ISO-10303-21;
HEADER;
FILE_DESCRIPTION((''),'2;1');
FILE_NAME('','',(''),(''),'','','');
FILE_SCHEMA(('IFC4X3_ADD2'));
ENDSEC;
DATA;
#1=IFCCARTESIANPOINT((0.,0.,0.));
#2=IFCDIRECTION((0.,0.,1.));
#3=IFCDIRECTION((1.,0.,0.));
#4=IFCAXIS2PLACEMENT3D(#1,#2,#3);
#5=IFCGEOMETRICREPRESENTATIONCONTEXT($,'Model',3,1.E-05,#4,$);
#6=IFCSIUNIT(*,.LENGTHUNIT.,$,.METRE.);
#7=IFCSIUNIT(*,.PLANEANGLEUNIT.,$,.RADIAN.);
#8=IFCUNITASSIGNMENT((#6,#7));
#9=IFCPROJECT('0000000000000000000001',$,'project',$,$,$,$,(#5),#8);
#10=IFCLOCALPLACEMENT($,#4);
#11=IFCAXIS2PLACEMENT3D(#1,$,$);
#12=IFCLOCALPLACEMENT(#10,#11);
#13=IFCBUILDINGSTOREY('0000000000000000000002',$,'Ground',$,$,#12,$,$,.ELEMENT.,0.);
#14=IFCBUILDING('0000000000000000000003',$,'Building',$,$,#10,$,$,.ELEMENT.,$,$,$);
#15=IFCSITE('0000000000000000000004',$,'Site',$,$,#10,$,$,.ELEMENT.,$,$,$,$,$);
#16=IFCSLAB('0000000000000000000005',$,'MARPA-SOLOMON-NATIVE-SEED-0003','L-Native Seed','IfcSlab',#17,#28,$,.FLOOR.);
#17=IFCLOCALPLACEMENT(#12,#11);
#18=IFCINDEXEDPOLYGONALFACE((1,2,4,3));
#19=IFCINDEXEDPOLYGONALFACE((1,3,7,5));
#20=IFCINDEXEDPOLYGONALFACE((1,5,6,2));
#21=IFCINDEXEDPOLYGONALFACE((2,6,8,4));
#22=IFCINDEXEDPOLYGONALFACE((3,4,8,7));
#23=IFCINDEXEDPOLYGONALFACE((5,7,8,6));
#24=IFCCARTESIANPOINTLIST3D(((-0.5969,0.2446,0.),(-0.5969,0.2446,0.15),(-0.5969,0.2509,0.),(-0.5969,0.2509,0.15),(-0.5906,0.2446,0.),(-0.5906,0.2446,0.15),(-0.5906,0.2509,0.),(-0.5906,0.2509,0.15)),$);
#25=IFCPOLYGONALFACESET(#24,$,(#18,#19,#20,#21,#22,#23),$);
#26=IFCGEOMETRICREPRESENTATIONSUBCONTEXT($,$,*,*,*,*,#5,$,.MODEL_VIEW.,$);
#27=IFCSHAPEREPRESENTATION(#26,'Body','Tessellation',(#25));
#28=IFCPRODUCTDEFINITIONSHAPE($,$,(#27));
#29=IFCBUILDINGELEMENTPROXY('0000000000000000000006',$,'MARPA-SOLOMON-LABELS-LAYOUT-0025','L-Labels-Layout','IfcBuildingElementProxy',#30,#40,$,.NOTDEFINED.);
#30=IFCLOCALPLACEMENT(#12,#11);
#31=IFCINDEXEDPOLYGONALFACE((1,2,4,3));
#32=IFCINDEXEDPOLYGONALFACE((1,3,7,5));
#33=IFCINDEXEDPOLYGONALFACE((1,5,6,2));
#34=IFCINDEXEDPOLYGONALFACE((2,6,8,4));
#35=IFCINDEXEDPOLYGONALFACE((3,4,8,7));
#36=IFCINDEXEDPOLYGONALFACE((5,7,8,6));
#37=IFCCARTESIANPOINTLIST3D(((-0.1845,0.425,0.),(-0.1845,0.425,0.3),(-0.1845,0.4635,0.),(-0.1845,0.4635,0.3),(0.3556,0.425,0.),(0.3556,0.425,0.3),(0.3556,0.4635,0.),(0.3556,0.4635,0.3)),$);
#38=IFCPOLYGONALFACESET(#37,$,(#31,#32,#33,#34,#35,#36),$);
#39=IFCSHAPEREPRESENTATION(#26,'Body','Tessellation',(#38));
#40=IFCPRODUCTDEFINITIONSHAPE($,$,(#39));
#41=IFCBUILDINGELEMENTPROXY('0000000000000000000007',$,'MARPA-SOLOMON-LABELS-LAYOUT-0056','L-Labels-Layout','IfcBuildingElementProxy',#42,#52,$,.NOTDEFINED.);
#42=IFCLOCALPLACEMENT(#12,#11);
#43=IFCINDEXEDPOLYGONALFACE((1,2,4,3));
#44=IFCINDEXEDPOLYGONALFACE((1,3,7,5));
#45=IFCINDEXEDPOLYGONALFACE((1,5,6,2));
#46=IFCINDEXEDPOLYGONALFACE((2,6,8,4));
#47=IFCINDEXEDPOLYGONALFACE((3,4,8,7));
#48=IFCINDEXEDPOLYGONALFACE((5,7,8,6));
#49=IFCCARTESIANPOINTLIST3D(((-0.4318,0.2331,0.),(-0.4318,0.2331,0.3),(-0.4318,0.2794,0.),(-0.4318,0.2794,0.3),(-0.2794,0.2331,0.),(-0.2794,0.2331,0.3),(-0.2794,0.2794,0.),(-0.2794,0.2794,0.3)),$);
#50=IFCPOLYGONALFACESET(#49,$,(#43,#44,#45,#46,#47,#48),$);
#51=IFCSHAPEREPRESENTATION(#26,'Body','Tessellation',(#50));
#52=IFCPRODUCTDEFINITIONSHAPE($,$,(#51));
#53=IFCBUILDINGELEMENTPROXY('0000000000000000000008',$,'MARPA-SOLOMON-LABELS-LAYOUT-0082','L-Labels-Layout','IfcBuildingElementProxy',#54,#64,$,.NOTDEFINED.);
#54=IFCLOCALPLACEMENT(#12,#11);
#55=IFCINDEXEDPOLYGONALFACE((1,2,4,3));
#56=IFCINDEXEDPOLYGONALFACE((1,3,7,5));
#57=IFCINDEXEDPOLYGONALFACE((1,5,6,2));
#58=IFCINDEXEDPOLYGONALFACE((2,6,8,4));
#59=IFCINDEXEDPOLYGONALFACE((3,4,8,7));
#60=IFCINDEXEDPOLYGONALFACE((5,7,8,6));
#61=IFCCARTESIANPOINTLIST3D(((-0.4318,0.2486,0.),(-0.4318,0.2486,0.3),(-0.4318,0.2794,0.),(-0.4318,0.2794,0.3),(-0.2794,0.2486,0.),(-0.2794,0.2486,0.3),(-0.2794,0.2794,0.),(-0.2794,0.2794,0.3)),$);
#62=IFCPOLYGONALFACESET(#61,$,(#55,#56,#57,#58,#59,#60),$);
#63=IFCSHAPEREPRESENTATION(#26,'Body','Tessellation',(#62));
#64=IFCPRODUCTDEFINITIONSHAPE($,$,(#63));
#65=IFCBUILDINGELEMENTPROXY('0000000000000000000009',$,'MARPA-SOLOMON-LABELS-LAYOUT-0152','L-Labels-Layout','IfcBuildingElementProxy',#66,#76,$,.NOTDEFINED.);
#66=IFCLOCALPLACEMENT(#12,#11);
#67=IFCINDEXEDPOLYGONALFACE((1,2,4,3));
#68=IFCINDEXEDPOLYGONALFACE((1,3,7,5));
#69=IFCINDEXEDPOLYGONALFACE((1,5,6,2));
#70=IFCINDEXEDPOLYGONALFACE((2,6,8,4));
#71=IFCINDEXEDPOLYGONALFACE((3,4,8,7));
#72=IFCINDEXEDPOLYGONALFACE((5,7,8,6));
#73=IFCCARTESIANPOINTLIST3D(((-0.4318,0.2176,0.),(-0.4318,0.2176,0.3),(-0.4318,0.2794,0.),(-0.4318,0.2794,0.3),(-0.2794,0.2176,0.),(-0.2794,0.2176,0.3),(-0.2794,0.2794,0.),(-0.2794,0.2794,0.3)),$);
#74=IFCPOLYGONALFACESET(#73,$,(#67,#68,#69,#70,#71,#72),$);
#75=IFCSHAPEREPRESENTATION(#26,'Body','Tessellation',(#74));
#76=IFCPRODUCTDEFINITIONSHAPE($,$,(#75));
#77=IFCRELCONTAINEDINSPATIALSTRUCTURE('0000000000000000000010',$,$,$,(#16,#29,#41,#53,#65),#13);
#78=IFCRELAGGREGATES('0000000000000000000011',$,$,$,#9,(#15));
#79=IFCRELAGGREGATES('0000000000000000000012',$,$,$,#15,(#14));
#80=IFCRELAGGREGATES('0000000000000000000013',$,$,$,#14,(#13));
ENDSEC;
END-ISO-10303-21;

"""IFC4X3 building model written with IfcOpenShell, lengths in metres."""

from ifc_helpers import new_model, si_unit, frame, origin, origin_with_axes, place, context, subcontext, project, spatial, polyline, outline, extrude, element, save


model = new_model("IFC4X3")

# Units and contexts
model_context = context("Model", 3, precision=1e-05, world=origin_with_axes())
sub_context = subcontext(model_context, None, None, "MODEL_VIEW")
ifc_project = project(units=[si_unit("LENGTHUNIT", "METRE"), si_unit("PLANEANGLEUNIT", "RADIAN")], contexts=[model_context])

# Site, building, storey
placement = place(None, origin_with_axes())
site = spatial("IfcSite", under=ifc_project, at=placement, Name="Site", CompositionType="ELEMENT")
building = spatial("IfcBuilding", under=site, at=placement, Name="Building", CompositionType="ELEMENT")
storey_placement = place(placement, origin())
storey = spatial("IfcBuildingStorey", under=building, at=storey_placement, Name="Ground", CompositionType="ELEMENT", Elevation=0.0)

# Slab
for number, where, name in (
    (1, (-0.5969, 0.2446, 0.0), "MARPA-SOLOMON-NATIVE-SEED-0003"),
):
    element("IfcSlab", number, at=place(storey_placement, frame(where)), inside=storey, Name=name, Description="L-Native Seed", ObjectType="IfcSlab", PredefinedType="FLOOR", context=sub_context, shape_type="SweptSolid", body=[
        extrude(outline(polyline([(0.0, 0.0063), (0.0063, 0.0063), (0.0063, 0.0), (0.0, 0.0), (0.0, 0.0063)])), origin(), (0.0, 0.0, 1.0), 0.15),
    ])

# Building element proxies
for number, where, name in (
    (2, (-0.1845, 0.425, 0.0), "MARPA-SOLOMON-LABELS-LAYOUT-0025"),
):
    element("IfcBuildingElementProxy", number, at=place(placement, frame(where)), inside=storey, Name=name, Description="L-Labels-Layout", ObjectType="IfcBuildingElementProxy", PredefinedType="NOTDEFINED", context=sub_context, shape_type="SweptSolid", body=[
        extrude(outline(polyline([(0.0, 0.0385), (0.5401, 0.0385), (0.5401, 0.0), (0.0, 0.0), (0.0, 0.0385)])), origin(), (0.0, 0.0, 1.0), 0.3),
    ])
proxy_1_placement = place(placement, frame((-0.4318, 0.2331, 0.0)))
element("IfcBuildingElementProxy", 3, at=proxy_1_placement, inside=storey, Name="MARPA-SOLOMON-LABELS-LAYOUT-0056", Description="L-Labels-Layout", ObjectType="IfcBuildingElementProxy", PredefinedType="NOTDEFINED", context=sub_context, shape_type="SweptSolid", body=[
    extrude(outline(polyline([(0.0, 0.0463), (0.1524, 0.0463), (0.1524, 0.0), (0.0, 0.0), (0.0, 0.0463)])), origin(), (0.0, 0.0, 1.0), 0.3),
])
for number, where, name in (
    (4, (-0.4318, 0.2486, 0.0), "MARPA-SOLOMON-LABELS-LAYOUT-0082"),
):
    element("IfcBuildingElementProxy", number, at=place(placement, frame(where)), inside=storey, Name=name, Description="L-Labels-Layout", ObjectType="IfcBuildingElementProxy", PredefinedType="NOTDEFINED", context=sub_context, shape_type="SweptSolid", body=[
        extrude(outline(polyline([(0.0, 0.0308), (0.1524, 0.0308), (0.1524, 0.0), (0.0, 0.0), (0.0, 0.0308)])), origin(), (0.0, 0.0, 1.0), 0.3),
    ])
proxy_2_placement = place(placement, frame((-0.4318, 0.2176, 0.0)))
element("IfcBuildingElementProxy", 5, at=proxy_2_placement, inside=storey, Name="MARPA-SOLOMON-LABELS-LAYOUT-0152", Description="L-Labels-Layout", ObjectType="IfcBuildingElementProxy", PredefinedType="NOTDEFINED", context=sub_context, shape_type="SweptSolid", body=[
    extrude(outline(polyline([(0.0, 0.0618), (0.1524, 0.0618), (0.1524, 0.0), (0.0, 0.0), (0.0, 0.0618)])), origin(), (0.0, 0.0, 1.0), 0.3),
])

save(model, "model.ifc")
